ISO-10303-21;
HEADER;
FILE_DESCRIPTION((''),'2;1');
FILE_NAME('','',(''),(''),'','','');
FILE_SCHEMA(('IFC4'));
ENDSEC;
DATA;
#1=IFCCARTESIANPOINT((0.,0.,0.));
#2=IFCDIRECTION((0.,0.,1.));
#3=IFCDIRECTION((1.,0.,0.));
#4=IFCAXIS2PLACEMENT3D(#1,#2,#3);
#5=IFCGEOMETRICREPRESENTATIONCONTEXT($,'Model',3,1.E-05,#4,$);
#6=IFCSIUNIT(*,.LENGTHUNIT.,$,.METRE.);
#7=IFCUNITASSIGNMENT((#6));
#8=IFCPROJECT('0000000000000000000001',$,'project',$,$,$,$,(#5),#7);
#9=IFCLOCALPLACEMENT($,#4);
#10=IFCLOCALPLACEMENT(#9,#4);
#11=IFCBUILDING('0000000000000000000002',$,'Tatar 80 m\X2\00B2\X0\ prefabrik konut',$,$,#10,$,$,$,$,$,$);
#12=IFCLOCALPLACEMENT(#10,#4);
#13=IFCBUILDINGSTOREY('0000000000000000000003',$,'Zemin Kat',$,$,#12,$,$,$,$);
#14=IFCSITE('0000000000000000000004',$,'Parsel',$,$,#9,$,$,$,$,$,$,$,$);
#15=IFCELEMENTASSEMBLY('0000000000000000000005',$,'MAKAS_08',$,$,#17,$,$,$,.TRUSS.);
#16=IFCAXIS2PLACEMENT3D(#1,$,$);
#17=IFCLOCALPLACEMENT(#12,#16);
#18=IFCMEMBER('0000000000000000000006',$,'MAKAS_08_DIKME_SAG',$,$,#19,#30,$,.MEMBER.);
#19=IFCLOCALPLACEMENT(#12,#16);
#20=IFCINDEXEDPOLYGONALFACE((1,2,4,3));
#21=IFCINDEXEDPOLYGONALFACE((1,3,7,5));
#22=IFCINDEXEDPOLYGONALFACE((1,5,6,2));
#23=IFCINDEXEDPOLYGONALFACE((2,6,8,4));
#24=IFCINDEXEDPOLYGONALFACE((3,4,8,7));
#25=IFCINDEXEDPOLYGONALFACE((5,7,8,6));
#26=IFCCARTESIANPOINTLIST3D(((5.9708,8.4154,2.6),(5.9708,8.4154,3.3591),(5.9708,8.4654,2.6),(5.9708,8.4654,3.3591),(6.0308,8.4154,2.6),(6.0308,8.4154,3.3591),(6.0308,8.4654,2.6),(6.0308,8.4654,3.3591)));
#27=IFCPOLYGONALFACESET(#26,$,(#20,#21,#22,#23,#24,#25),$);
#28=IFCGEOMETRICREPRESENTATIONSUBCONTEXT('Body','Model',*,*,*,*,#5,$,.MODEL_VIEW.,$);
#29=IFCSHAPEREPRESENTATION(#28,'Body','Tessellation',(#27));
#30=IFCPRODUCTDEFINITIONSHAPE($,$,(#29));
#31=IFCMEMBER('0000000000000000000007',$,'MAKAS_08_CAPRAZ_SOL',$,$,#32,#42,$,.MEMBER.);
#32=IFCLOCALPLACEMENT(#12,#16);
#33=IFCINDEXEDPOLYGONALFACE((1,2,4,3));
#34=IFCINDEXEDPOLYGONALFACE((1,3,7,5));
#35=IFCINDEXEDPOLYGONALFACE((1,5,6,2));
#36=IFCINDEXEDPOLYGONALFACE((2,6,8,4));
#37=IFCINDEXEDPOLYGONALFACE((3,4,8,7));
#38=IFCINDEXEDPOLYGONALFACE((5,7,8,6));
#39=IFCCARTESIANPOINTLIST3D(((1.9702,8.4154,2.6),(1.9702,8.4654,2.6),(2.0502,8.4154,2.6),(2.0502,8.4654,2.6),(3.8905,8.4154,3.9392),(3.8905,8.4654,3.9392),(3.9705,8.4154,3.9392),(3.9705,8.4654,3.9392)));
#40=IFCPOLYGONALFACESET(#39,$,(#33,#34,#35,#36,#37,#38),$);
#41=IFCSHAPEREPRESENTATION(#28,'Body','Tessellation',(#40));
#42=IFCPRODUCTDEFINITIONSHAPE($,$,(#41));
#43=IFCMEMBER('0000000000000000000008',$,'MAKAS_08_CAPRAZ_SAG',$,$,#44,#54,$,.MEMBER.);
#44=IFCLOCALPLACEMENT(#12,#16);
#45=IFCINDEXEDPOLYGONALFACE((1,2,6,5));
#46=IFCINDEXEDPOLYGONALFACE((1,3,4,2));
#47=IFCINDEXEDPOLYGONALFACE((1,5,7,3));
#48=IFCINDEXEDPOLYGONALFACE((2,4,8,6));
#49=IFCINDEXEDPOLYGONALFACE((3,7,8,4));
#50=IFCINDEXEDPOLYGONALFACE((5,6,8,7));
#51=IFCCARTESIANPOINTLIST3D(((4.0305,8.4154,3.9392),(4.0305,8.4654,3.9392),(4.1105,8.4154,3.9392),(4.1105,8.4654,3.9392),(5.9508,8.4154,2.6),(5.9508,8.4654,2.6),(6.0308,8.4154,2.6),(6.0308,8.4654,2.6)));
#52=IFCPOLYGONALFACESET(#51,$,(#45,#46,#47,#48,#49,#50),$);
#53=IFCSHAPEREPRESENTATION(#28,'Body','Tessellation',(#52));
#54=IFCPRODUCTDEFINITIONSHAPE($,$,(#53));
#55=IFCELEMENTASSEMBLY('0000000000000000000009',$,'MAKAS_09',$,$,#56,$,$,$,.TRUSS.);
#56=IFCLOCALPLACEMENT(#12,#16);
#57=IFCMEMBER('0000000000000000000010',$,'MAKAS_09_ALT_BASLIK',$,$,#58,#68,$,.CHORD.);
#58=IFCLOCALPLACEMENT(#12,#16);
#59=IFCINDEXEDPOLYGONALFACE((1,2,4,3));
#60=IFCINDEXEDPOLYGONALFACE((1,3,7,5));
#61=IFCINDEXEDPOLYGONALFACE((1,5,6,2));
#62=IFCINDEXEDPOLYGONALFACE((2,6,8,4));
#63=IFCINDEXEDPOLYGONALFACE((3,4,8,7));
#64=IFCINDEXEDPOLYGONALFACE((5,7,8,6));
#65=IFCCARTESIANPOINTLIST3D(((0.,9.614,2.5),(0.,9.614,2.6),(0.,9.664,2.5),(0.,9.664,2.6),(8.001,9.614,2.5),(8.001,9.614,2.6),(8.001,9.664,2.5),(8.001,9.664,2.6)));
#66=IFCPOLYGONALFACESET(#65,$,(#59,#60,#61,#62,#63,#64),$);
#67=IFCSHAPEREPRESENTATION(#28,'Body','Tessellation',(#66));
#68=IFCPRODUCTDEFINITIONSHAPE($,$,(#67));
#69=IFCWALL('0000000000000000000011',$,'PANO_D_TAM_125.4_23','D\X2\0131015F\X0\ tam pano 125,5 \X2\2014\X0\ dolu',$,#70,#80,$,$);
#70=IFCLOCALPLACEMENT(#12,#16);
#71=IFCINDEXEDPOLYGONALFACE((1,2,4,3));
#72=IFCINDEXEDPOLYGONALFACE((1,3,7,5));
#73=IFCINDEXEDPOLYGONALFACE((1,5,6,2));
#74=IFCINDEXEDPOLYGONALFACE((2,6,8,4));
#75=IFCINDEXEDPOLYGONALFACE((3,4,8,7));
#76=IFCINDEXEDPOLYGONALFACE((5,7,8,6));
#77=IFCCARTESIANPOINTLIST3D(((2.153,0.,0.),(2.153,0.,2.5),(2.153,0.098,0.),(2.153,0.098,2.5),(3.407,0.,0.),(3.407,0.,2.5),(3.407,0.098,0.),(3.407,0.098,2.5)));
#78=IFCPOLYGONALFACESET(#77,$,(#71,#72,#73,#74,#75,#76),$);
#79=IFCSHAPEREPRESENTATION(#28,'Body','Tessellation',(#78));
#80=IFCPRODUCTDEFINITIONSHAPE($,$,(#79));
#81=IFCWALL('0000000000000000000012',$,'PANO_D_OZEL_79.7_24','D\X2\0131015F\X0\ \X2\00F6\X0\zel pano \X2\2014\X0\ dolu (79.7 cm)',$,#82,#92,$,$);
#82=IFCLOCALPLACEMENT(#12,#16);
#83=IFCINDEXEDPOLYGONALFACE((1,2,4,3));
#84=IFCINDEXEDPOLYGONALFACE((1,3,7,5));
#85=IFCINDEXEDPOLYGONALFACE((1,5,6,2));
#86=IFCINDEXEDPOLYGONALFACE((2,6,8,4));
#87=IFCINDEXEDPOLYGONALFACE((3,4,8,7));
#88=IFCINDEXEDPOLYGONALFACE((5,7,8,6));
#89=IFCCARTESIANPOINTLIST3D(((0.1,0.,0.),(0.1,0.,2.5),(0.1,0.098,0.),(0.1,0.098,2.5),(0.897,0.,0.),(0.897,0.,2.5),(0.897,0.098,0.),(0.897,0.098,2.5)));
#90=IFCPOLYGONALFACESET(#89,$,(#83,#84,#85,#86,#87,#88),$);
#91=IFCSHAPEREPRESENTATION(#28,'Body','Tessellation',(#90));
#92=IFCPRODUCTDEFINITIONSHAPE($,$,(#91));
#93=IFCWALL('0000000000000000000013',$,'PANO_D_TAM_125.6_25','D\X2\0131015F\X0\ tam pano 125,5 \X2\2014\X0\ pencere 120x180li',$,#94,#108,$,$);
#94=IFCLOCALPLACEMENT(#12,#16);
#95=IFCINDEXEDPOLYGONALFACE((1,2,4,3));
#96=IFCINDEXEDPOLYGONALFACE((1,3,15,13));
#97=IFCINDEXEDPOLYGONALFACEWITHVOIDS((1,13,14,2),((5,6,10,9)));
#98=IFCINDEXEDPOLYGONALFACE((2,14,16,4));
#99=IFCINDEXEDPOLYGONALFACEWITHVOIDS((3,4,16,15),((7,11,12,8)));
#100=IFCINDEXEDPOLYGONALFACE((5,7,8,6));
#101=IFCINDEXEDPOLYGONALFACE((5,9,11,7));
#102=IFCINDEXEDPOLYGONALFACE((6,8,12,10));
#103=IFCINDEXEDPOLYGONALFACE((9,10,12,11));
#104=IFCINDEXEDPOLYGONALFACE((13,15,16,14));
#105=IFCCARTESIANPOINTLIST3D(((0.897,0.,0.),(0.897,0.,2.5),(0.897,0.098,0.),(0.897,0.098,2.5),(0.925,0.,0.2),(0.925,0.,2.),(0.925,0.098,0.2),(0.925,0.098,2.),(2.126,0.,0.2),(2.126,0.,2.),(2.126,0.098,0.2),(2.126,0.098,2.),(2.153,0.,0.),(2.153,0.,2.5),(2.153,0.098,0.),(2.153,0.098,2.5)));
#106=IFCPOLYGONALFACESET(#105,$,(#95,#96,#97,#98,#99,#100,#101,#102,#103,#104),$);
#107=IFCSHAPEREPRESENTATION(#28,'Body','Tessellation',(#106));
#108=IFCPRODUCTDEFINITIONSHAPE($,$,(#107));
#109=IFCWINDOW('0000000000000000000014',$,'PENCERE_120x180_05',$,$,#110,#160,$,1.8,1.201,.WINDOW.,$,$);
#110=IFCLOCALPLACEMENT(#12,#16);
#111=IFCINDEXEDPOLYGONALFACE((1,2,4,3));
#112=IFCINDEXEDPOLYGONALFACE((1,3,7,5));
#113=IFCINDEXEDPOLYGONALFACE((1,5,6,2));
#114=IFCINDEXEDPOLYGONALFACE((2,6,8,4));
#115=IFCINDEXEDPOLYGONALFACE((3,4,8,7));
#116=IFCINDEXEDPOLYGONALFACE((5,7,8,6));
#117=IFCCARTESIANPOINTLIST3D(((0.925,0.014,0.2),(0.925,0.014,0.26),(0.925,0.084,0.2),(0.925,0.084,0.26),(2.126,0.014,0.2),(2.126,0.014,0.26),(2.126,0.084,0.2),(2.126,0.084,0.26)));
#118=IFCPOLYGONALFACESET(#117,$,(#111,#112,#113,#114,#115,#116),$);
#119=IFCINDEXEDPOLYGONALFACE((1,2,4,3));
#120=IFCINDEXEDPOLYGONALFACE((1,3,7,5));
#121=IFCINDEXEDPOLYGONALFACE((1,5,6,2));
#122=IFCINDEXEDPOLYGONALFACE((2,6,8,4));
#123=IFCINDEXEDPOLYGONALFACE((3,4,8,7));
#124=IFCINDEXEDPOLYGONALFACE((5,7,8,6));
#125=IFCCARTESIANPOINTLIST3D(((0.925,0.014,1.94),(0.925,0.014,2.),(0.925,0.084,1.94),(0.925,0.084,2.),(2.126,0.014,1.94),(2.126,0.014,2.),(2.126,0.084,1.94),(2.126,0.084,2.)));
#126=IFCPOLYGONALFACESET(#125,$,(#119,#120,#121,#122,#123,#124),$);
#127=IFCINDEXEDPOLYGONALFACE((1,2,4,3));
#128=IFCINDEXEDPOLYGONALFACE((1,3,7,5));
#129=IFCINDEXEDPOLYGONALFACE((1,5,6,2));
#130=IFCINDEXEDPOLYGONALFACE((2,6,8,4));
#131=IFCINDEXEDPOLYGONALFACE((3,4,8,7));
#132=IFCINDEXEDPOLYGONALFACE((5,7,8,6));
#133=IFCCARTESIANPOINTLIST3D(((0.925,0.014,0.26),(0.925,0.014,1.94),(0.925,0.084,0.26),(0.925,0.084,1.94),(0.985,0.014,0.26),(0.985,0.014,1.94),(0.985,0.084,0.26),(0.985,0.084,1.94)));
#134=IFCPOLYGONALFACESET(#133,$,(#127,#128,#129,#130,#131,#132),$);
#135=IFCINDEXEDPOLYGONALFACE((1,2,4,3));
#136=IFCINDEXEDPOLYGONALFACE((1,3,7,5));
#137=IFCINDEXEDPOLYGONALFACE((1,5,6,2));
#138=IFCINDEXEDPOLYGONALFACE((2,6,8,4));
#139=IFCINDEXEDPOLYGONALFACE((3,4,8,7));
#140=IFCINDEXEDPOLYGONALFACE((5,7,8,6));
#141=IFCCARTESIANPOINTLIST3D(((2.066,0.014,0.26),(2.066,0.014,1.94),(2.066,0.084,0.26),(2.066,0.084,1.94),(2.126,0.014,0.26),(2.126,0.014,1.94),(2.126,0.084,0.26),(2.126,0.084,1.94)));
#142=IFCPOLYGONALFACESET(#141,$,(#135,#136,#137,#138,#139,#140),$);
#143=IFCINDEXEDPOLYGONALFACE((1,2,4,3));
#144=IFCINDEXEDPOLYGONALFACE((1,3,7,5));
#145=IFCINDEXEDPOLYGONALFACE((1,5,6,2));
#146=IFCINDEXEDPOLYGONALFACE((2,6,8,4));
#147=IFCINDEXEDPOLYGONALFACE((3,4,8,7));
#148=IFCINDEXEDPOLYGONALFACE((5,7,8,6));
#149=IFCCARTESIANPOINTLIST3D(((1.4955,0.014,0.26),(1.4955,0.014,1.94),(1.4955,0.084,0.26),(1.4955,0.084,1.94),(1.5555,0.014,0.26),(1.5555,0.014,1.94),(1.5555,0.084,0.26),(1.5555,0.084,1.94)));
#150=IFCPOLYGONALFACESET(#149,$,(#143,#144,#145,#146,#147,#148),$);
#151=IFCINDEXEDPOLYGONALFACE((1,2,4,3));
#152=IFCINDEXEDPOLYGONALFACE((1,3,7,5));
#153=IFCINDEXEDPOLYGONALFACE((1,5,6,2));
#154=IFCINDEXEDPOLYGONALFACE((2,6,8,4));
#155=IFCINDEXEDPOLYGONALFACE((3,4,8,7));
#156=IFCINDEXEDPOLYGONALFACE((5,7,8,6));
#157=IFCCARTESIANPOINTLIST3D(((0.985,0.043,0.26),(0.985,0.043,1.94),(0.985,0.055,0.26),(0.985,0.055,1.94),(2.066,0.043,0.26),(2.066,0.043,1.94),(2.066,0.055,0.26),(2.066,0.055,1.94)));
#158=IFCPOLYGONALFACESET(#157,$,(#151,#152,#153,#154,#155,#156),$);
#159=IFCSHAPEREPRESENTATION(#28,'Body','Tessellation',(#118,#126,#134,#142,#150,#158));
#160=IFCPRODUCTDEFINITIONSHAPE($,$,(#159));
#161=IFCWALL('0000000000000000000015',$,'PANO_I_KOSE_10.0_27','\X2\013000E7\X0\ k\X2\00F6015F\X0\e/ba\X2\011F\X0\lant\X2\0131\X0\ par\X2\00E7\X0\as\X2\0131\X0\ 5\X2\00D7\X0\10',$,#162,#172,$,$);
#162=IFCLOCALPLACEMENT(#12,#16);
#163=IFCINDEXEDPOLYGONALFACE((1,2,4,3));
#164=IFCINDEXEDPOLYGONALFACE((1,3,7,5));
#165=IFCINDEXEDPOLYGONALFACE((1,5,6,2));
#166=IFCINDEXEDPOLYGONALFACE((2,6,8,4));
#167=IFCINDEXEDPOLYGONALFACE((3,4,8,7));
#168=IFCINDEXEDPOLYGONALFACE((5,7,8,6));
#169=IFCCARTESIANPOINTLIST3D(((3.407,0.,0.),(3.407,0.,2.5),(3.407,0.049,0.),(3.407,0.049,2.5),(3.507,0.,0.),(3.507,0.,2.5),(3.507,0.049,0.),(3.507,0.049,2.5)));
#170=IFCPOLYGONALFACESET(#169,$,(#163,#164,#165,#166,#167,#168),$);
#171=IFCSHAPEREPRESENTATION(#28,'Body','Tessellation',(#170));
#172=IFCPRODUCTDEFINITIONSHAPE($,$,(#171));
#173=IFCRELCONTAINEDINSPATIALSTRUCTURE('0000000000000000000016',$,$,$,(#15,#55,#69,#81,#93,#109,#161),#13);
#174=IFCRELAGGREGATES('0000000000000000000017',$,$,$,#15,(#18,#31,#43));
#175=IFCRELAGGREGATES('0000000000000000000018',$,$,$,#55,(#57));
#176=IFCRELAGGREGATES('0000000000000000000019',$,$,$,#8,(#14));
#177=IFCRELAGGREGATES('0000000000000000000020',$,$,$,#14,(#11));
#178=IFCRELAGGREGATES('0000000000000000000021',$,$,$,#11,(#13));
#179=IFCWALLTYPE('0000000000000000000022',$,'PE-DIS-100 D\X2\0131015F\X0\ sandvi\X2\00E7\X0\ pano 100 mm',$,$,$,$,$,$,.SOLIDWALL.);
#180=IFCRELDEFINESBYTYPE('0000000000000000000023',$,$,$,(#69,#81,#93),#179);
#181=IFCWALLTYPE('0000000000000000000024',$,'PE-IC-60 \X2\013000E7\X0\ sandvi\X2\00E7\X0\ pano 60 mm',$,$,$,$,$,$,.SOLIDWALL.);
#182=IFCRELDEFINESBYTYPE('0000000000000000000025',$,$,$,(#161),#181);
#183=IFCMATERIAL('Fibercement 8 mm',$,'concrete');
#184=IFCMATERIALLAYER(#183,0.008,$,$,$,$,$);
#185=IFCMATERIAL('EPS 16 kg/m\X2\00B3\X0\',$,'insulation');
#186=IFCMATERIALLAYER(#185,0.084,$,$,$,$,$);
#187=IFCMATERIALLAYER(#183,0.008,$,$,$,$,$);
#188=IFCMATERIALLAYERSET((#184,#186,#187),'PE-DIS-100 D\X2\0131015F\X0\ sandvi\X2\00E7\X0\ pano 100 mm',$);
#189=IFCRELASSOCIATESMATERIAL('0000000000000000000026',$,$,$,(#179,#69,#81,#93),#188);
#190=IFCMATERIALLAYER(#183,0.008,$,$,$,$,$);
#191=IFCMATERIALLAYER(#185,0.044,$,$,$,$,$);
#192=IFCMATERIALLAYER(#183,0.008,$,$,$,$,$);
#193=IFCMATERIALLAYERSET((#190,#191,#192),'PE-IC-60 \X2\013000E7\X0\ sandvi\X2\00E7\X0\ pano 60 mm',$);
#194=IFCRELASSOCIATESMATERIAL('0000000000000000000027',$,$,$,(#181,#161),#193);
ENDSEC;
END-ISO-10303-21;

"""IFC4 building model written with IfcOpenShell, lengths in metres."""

from ifc_helpers import new_model, si_unit, frame, origin_with_axes, place, context, subcontext, project, spatial, line, indexed_curve, outline, extrude, material, layer, layer_set, layer_usage, type_object, element, fill, aggregate, save


model = new_model("IFC4")

# Units and contexts
model_context = context("Model", 3, precision=1e-05, world=origin_with_axes())
body_context = subcontext(model_context, "Body", "Model", "MODEL_VIEW")
ifc_project = project(units=[si_unit("LENGTHUNIT", "METRE")], contexts=[model_context])

# Site, building, storey
site_placement = place(None, origin_with_axes())
site = spatial("IfcSite", under=ifc_project, at=site_placement, Name="Parsel")
building_placement = place(site_placement, origin_with_axes())
building = spatial("IfcBuilding", under=site, at=building_placement, Name="Tatar 80 m² prefabrik konut")
storey_placement = place(building_placement, origin_with_axes())
storey = spatial("IfcBuildingStorey", under=building, at=storey_placement, Name="Zemin Kat")

# Element assembly, members
assembly_1_placement = place(storey_placement, origin_with_axes())
assembly_1 = element("IfcElementAssembly", 1, at=assembly_1_placement, inside=storey, Name="MAKAS_08", PredefinedType="TRUSS")
member_1_placement = place(assembly_1_placement, origin_with_axes())
member_1 = element("IfcMember", 2, at=member_1_placement, Name="MAKAS_08_DIKME_SAG", PredefinedType="MEMBER", context=body_context, shape_type="SweptSolid", body=[
    extrude(outline(indexed_curve([(5.9708, 2.6), (6.0308, 2.6), (6.0308, 3.3591), (5.9708, 3.3591)], segments=[line(1, 2, 3, 4, 1)])), frame((0.0, 8.4654, 0.0), z_axis=(0.0, -1.0, 0.0), x_axis=(1.0, 0.0, 0.0)), (0.0, 0.0, 1.0), 0.05),
])
member_2_placement = place(assembly_1_placement, origin_with_axes())
member_2 = element("IfcMember", 3, at=member_2_placement, Name="MAKAS_08_CAPRAZ_SOL", PredefinedType="MEMBER", context=body_context, shape_type="SweptSolid", body=[
    extrude(outline(indexed_curve([(1.9703, 2.6), (2.0503, 2.6), (3.9705, 3.9392), (3.8905, 3.9392)], segments=[line(1, 2, 3, 4, 1)])), frame((0.0, 8.4654, 0.0), z_axis=(0.0, -1.0, 0.0), x_axis=(1.0, 0.0, 0.0)), (0.0, 0.0, 1.0), 0.05),
])
member_3_placement = place(assembly_1_placement, origin_with_axes())
member_3 = element("IfcMember", 4, at=member_3_placement, Name="MAKAS_08_CAPRAZ_SAG", PredefinedType="MEMBER", context=body_context, shape_type="SweptSolid", body=[
    extrude(outline(indexed_curve([(5.9508, 2.6), (6.0308, 2.6), (4.1105, 3.9392), (4.0305, 3.9392)], segments=[line(1, 2, 3, 4, 1)])), frame((0.0, 8.4654, 0.0), z_axis=(0.0, -1.0, 0.0), x_axis=(1.0, 0.0, 0.0)), (0.0, 0.0, 1.0), 0.05),
])
aggregate(assembly_1, [member_1, member_2, member_3])

# Element assembly, member
assembly_2_placement = place(storey_placement, origin_with_axes())
assembly_2 = element("IfcElementAssembly", 5, at=assembly_2_placement, inside=storey, Name="MAKAS_09", PredefinedType="TRUSS")
member_4_placement = place(assembly_2_placement, origin_with_axes())
member_4 = element("IfcMember", 6, at=member_4_placement, Name="MAKAS_09_ALT_BASLIK", PredefinedType="CHORD", context=body_context, shape_type="SweptSolid", body=[
    extrude(outline(indexed_curve([(0.0, 2.5), (8.001, 2.5), (8.001, 2.6), (0.0, 2.6)], segments=[line(1, 2, 3, 4, 1)])), frame((0.0, 9.664, 0.0), z_axis=(0.0, -1.0, 0.0), x_axis=(1.0, 0.0, 0.0)), (0.0, 0.0, 1.0), 0.05),
])
aggregate(assembly_2, [member_4])

# Walls
ifc_material_1 = material(Name="Fibercement 8 mm", Category="concrete")
ifc_layer_1 = layer(ifc_material_1, 0.008)
ifc_material_2 = material(Name="EPS 16 kg/m³", Category="insulation")
ifc_layer_2 = layer(ifc_material_2, 0.084)
ifc_layer_3 = layer(ifc_material_1, 0.008)
ifc_layer_set_1 = layer_set([ifc_layer_1, ifc_layer_2, ifc_layer_3], Name="PE-DIS-100 Dış sandviç pano 100 mm")
ifc_layer_usage_1 = layer_usage(ifc_layer_set_1, "AXIS2", "POSITIVE", 0.0)
wall_type_1 = type_object("IfcWallType", Name="PE-DIS-100 Dış sandviç pano 100 mm", PredefinedType="SOLIDWALL", material=ifc_layer_set_1)
wall_1_placement = place(storey_placement, frame((2.153, 0.0, 0.0), z_axis=(0.0, 0.0, 1.0), x_axis=(1.0, 0.0, 0.0)))
element("IfcWall", 7, at=wall_1_placement, inside=storey, type_object=wall_type_1, material=ifc_layer_usage_1, Name="PANO_D_TAM_125.4_23", Description="Dış tam pano 125,5 — dolu", context=body_context, shape_type="SweptSolid", body=[
    extrude(outline(indexed_curve([(0.0, 0.0), (1.254, 0.0), (1.254, 0.098), (0.0, 0.098)], segments=[line(1, 2, 3, 4, 1)])), origin_with_axes(), (0.0, 0.0, 1.0), 2.5),
])
ifc_layer_usage_2 = layer_usage(ifc_layer_set_1, "AXIS2", "POSITIVE", 0.0)
wall_2_placement = place(storey_placement, frame((0.1, 0.0, 0.0), z_axis=(0.0, 0.0, 1.0), x_axis=(1.0, 0.0, 0.0)))
element("IfcWall", 8, at=wall_2_placement, inside=storey, type_object=wall_type_1, material=ifc_layer_usage_2, Name="PANO_D_OZEL_79.7_24", Description="Dış özel pano — dolu (79.7 cm)", context=body_context, shape_type="SweptSolid", body=[
    extrude(outline(indexed_curve([(0.0, 0.0), (0.797, 0.0), (0.797, 0.098), (0.0, 0.098)], segments=[line(1, 2, 3, 4, 1)])), origin_with_axes(), (0.0, 0.0, 1.0), 2.5),
])

# Wall, opening, window
ifc_layer_usage_3 = layer_usage(ifc_layer_set_1, "AXIS2", "POSITIVE", 0.0)
wall_3_placement = place(storey_placement, frame((0.897, 0.0, 0.0), z_axis=(0.0, 0.0, 1.0), x_axis=(1.0, 0.0, 0.0)))
wall_3 = element("IfcWall", 9, at=wall_3_placement, inside=storey, type_object=wall_type_1, material=ifc_layer_usage_3, Name="PANO_D_TAM_125.6_25", Description="Dış tam pano 125,5 — pencere 120x180li", context=body_context, shape_type="SweptSolid", body=[
    extrude(outline(indexed_curve([(0.0, 0.0), (1.256, 0.0), (1.256, 0.098), (0.0, 0.098)], segments=[line(1, 2, 3, 4, 1)])), origin_with_axes(), (0.0, 0.0, 1.0), 2.5),
])
opening_placement = place(wall_3_placement, origin_with_axes())
opening = element("IfcOpeningElement", 10, at=opening_placement, cuts=wall_3, PredefinedType="OPENING", context=body_context, shape_type="SweptSolid", body=[
    extrude(outline(indexed_curve([(0.0, 0.0), (1.201, 0.0), (1.201, 0.138), (0.0, 0.138)], segments=[line(1, 2, 3, 4, 1)])), frame((0.028, -0.02, 0.2), z_axis=(0.0, 0.0, 1.0), x_axis=(1.0, 0.0, 0.0)), (0.0, 0.0, 1.0), 1.8),
])
window_placement = place(storey_placement, frame((0.897, 0.0, 0.0), z_axis=(0.0, 0.0, 1.0), x_axis=(1.0, 0.0, 0.0)))
window = element("IfcWindow", 11, at=window_placement, inside=storey, Name="PENCERE_120x180_05", OverallHeight=1.8, OverallWidth=1.201, PredefinedType="WINDOW", context=body_context, shape_type="SweptSolid", body=[
    extrude(outline(indexed_curve([(0.0, 0.0), (1.201, 0.0), (1.201, 0.07), (0.0, 0.07)], segments=[line(1, 2, 3, 4, 1)])), frame((0.028, 0.014, 0.2), z_axis=(0.0, 0.0, 1.0), x_axis=(1.0, 0.0, 0.0)), (0.0, 0.0, 1.0), 0.06),
    extrude(outline(indexed_curve([(0.0, 0.0), (1.201, 0.0), (1.201, 0.07), (0.0, 0.07)], segments=[line(1, 2, 3, 4, 1)])), frame((0.028, 0.014, 1.94), z_axis=(0.0, 0.0, 1.0), x_axis=(1.0, 0.0, 0.0)), (0.0, 0.0, 1.0), 0.06),
    extrude(outline(indexed_curve([(0.0, 0.0), (0.06, 0.0), (0.06, 0.07), (0.0, 0.07)], segments=[line(1, 2, 3, 4, 1)])), frame((0.028, 0.014, 0.26), z_axis=(0.0, 0.0, 1.0), x_axis=(1.0, 0.0, 0.0)), (0.0, 0.0, 1.0), 1.68),
    extrude(outline(indexed_curve([(0.0, 0.0), (0.06, 0.0), (0.06, 0.07), (0.0, 0.07)], segments=[line(1, 2, 3, 4, 1)])), frame((1.169, 0.014, 0.26), z_axis=(0.0, 0.0, 1.0), x_axis=(1.0, 0.0, 0.0)), (0.0, 0.0, 1.0), 1.68),
    extrude(outline(indexed_curve([(0.0, 0.0), (0.06, 0.0), (0.06, 0.07), (0.0, 0.07)], segments=[line(1, 2, 3, 4, 1)])), frame((0.5985, 0.014, 0.26), z_axis=(0.0, 0.0, 1.0), x_axis=(1.0, 0.0, 0.0)), (0.0, 0.0, 1.0), 1.68),
    extrude(outline(indexed_curve([(0.0, 0.0), (1.081, 0.0), (1.081, 0.012), (0.0, 0.012)], segments=[line(1, 2, 3, 4, 1)])), frame((0.088, 0.043, 0.26), z_axis=(0.0, 0.0, 1.0), x_axis=(1.0, 0.0, 0.0)), (0.0, 0.0, 1.0), 1.68),
])
fill(opening, window)

# Wall
ifc_layer_4 = layer(ifc_material_1, 0.008)
ifc_layer_5 = layer(ifc_material_2, 0.044)
ifc_layer_6 = layer(ifc_material_1, 0.008)
ifc_layer_set_2 = layer_set([ifc_layer_4, ifc_layer_5, ifc_layer_6], Name="PE-IC-60 İç sandviç pano 60 mm")
ifc_layer_usage_4 = layer_usage(ifc_layer_set_2, "AXIS2", "POSITIVE", 0.0)
wall_type_2 = type_object("IfcWallType", Name="PE-IC-60 İç sandviç pano 60 mm", PredefinedType="SOLIDWALL", material=ifc_layer_set_2)
wall_4_placement = place(storey_placement, frame((3.407, 0.0, 0.0), z_axis=(0.0, 0.0, 1.0), x_axis=(1.0, 0.0, 0.0)))
element("IfcWall", 12, at=wall_4_placement, inside=storey, type_object=wall_type_2, material=ifc_layer_usage_4, Name="PANO_I_KOSE_10.0_27", Description="İç köşe/bağlantı parçası 5×10", context=body_context, shape_type="SweptSolid", body=[
    extrude(outline(indexed_curve([(0.0, 0.0), (0.1, 0.0), (0.1, 0.049), (0.0, 0.049)], segments=[line(1, 2, 3, 4, 1)])), origin_with_axes(), (0.0, 0.0, 1.0), 2.5),
])

save(model, "model.ifc")
